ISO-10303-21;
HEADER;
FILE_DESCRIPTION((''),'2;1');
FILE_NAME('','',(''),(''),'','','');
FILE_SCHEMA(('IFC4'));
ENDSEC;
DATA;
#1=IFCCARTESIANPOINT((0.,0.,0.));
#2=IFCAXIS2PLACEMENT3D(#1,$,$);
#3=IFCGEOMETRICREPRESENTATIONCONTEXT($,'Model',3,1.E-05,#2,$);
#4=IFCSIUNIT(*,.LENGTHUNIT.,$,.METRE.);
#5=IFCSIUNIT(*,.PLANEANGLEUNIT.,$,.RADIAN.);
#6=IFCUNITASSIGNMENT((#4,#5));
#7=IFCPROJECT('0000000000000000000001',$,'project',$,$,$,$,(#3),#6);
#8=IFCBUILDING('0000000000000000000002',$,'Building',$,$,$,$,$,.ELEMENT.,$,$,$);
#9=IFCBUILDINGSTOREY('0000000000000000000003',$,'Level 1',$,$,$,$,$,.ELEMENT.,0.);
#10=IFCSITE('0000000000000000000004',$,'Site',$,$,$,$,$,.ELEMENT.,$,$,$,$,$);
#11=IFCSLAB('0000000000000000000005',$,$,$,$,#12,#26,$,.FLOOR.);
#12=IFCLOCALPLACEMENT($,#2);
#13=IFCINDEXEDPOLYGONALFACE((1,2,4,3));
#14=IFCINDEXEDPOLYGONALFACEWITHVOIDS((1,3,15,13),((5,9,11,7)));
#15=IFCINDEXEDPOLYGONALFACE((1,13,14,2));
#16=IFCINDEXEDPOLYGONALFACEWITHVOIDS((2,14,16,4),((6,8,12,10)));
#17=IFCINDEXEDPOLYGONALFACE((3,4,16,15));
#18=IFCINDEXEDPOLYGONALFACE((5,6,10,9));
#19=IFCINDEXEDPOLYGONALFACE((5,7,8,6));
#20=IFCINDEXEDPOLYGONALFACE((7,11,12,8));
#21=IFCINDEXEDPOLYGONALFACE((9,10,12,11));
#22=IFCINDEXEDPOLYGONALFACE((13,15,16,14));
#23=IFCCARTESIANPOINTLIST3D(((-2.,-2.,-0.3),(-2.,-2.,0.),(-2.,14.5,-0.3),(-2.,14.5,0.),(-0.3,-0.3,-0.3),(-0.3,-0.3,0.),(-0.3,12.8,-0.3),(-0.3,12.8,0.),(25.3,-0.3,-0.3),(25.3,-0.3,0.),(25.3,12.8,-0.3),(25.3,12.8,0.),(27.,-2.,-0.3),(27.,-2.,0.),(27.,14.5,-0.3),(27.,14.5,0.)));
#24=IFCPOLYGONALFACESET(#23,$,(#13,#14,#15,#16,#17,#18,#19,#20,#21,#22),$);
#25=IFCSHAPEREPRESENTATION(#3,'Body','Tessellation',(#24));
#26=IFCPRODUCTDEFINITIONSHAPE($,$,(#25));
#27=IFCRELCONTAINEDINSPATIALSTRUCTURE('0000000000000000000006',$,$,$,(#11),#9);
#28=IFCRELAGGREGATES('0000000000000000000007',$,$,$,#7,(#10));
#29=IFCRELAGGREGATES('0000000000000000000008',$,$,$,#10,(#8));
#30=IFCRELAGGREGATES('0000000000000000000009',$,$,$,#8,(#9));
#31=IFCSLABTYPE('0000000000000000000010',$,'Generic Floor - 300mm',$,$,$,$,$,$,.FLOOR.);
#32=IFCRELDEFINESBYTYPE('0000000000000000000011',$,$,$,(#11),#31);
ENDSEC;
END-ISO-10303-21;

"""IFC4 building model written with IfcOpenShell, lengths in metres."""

from ifc_helpers import new_model, si_unit, frame, origin, place, context, project, spatial, polyline, outline, extrude, type_object, element, save


model = new_model("IFC4")

# Units and contexts
model_context = context("Model", 3, precision=1e-05, world=origin())
ifc_project = project(units=[si_unit("LENGTHUNIT", "METRE"), si_unit("PLANEANGLEUNIT", "RADIAN")], contexts=[model_context])

# Site, building, storey
site = spatial("IfcSite", under=ifc_project, Name="Site", CompositionType="ELEMENT")
building = spatial("IfcBuilding", under=site, Name="Building", CompositionType="ELEMENT")
storey = spatial("IfcBuildingStorey", under=building, Name="Level 1", CompositionType="ELEMENT", Elevation=0.0)

# Slab, opening
slab_type = type_object("IfcSlabType", Name="Generic Floor - 300mm", PredefinedType="FLOOR")
slab_placement = place(None, origin())
slab = element("IfcSlab", 1, at=slab_placement, inside=storey, type_object=slab_type, PredefinedType="FLOOR", context=model_context, shape_type="SweptSolid", body=[
    extrude(outline(polyline([(-2.0, -2.0), (27.0, -2.0), (27.0, 14.5), (-2.0, 14.5), (-2.0, -2.0)])), origin(), (0.0, 0.0, -1.0), 0.3),
])
opening_placement = place(None, frame((0.0, 0.0, 0.001)))
element("IfcOpeningElement", 2, at=opening_placement, cuts=slab, PredefinedType="OPENING", context=model_context, shape_type="SweptSolid", body=[
    extrude(outline(polyline([(-0.3, 12.8), (-0.3, -0.3), (25.3, -0.3), (25.3, 12.8), (-0.3, 12.8)])), origin(), (0.0, 0.0, -1.0), 0.302),
])

save(model, "model.ifc")
